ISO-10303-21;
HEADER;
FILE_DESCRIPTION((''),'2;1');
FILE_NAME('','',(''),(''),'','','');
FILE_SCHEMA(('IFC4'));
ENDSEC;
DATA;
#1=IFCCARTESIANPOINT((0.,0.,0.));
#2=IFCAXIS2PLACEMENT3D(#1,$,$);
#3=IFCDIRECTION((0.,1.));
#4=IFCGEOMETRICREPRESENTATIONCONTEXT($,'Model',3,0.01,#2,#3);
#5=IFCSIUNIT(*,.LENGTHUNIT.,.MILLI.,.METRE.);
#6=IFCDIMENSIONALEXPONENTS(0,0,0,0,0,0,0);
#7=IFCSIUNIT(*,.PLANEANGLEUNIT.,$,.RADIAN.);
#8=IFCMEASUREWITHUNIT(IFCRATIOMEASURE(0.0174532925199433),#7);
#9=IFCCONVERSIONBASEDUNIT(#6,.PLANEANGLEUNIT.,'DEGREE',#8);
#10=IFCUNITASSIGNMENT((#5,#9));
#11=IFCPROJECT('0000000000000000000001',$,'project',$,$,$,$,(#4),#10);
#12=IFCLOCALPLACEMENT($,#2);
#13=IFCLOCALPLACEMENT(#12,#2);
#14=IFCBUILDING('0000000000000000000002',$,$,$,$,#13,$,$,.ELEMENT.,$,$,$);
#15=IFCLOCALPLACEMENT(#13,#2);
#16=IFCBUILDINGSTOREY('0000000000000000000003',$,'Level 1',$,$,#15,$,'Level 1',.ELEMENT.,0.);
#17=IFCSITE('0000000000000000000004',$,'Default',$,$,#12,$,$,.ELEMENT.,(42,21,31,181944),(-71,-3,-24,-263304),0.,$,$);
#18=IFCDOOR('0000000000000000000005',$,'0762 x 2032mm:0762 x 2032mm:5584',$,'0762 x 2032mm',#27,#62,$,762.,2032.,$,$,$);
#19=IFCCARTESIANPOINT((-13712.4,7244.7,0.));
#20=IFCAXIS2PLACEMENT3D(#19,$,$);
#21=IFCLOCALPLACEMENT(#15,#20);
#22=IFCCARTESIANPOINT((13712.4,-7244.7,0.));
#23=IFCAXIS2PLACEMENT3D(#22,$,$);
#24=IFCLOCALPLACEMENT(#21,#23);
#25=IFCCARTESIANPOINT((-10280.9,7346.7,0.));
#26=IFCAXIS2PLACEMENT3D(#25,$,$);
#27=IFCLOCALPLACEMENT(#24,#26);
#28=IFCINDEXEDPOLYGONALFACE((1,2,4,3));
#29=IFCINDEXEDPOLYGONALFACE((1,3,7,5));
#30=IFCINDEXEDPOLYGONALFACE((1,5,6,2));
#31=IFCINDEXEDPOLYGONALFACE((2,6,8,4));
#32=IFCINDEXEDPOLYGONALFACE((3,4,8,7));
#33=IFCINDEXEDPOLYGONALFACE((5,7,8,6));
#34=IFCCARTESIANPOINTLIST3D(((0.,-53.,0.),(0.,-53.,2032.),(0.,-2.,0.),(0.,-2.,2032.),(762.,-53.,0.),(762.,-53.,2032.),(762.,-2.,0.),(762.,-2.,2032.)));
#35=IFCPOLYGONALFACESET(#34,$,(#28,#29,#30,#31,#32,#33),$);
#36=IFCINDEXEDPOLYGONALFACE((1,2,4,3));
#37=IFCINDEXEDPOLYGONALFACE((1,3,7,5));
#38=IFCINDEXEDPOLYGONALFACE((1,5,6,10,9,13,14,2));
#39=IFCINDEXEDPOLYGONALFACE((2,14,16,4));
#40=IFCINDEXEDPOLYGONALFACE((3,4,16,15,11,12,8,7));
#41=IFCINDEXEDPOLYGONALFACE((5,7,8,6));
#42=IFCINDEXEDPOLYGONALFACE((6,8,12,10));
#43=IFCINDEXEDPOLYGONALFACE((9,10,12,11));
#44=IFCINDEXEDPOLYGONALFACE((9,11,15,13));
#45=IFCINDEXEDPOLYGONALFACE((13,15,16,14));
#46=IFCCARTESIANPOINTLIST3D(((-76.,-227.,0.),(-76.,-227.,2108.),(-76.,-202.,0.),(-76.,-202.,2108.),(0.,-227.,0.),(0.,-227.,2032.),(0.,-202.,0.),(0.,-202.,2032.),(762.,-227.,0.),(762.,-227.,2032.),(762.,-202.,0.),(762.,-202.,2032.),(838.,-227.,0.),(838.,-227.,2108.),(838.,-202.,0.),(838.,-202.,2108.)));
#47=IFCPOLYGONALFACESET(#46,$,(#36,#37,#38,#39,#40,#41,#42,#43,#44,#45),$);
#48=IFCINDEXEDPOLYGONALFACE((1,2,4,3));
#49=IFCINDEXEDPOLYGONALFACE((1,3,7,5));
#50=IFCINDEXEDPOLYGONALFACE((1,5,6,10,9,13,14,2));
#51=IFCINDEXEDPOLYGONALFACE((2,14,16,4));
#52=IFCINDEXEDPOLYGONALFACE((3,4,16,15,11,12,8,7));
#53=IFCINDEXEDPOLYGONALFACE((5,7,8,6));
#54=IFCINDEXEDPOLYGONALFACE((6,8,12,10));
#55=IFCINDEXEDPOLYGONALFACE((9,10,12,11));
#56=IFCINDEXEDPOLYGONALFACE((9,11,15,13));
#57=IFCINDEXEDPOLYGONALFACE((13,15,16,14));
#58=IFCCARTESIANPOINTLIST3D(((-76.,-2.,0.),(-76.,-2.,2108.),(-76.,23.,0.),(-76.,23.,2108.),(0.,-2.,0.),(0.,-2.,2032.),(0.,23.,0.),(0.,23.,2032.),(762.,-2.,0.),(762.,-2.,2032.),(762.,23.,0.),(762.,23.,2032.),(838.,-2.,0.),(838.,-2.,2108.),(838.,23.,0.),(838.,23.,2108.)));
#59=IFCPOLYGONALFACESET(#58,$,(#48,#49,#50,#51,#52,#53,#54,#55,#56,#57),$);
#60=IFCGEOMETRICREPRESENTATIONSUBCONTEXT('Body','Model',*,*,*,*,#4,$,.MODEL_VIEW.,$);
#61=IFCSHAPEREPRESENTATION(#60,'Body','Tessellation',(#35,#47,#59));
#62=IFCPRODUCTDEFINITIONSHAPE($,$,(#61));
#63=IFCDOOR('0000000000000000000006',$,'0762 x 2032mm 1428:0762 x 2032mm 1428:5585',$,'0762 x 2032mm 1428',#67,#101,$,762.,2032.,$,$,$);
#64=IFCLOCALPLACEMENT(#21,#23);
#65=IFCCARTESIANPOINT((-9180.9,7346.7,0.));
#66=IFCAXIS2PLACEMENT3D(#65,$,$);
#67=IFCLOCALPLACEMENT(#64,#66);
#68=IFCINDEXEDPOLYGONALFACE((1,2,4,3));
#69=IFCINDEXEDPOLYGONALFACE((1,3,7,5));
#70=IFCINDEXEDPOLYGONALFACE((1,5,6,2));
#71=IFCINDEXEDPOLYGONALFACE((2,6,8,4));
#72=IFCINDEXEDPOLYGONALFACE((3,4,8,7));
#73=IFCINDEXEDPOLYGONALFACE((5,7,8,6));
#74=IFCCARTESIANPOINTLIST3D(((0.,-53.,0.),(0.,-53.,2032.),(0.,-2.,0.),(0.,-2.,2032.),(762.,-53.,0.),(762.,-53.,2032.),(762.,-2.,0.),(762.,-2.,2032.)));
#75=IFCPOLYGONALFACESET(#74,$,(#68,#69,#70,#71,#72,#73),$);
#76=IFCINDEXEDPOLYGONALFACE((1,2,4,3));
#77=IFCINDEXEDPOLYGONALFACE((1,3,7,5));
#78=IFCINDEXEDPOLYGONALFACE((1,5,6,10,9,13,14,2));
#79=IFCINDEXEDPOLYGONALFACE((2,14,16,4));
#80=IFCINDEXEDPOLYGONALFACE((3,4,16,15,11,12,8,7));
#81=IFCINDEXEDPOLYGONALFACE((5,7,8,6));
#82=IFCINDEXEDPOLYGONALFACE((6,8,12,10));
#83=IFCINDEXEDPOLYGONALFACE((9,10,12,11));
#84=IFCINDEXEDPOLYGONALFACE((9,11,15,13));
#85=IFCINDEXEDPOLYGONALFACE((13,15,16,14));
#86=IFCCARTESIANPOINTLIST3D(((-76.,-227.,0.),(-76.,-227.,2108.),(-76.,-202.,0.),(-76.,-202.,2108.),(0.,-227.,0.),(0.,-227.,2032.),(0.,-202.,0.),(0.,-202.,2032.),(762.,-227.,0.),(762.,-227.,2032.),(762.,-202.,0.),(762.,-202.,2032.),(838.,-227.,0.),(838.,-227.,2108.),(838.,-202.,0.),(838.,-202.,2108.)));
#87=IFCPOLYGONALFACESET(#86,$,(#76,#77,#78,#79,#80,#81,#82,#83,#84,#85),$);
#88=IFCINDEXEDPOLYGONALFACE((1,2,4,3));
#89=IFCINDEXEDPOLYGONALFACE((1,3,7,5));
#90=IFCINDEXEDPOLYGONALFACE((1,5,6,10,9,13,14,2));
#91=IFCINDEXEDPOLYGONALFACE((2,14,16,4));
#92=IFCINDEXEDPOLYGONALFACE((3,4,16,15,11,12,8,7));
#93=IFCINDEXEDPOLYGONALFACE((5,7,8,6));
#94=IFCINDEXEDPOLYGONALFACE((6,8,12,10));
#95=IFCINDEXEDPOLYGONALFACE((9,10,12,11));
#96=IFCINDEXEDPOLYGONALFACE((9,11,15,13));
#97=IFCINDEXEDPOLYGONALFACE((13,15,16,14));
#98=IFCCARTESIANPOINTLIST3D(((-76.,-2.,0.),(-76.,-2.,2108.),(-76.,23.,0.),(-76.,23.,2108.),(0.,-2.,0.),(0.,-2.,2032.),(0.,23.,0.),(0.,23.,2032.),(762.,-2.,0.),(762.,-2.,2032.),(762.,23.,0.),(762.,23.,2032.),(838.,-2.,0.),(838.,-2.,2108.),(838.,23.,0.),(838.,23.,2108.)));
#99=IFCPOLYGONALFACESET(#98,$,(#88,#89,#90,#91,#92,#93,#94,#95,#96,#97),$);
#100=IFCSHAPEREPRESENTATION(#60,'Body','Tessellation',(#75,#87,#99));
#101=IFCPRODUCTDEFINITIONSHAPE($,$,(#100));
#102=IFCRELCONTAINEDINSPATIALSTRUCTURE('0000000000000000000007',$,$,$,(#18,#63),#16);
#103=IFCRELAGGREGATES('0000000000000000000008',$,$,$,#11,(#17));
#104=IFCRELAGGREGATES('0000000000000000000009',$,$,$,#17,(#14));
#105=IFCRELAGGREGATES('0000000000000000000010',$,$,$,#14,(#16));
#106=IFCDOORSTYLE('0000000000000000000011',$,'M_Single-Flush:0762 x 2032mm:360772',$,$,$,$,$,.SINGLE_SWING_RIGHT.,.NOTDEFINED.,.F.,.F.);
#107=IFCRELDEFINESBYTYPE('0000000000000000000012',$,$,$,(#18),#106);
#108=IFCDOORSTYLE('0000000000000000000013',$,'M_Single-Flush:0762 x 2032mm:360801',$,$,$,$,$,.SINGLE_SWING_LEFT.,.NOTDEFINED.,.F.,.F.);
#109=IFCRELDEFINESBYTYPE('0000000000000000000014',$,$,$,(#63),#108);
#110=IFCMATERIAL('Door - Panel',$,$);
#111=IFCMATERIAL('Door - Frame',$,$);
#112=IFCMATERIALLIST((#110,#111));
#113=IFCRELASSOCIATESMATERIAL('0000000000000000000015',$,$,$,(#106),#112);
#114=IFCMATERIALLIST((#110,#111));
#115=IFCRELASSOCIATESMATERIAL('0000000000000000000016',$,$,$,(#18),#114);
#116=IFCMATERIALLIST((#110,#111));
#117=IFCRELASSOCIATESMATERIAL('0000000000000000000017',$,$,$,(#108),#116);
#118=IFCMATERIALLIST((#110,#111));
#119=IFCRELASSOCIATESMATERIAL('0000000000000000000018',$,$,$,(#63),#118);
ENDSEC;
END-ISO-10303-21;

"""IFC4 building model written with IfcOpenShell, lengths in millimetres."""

from ifc_helpers import new_model, entity, si_unit, converted_unit, direction, frame, frame_2d, origin, origin_2d_with_axis, place, context, subcontext, project, spatial, polyline, rectangle, outline, extrude, source, transform, mapped, material, material_list, type_object, type_shapes, element, save


model = new_model("IFC4")

# Units and contexts
model_context = context("Model", 3, precision=0.01, world=origin(), true_north=direction((0.0, 1.0)))
body_context = subcontext(model_context, "Body", "Model", "MODEL_VIEW")
ifc_project = project(units=[si_unit("LENGTHUNIT", "METRE", prefix="MILLI"), converted_unit("PLANEANGLEUNIT", "DEGREE", entity("IfcRatioMeasure", 0.0174532925199433), si_unit("PLANEANGLEUNIT", "RADIAN"), dimensions=[0, 0, 0, 0, 0, 0, 0])], contexts=[model_context])

# Site, building, storey
site_placement = place(None, origin())
site = spatial("IfcSite", under=ifc_project, at=site_placement, Name="Default", CompositionType="ELEMENT", RefLatitude=(42, 21, 31, 181944), RefLongitude=(-71, -3, -24, -263304), RefElevation=0.0)
building_placement = place(site_placement, origin())
building = spatial("IfcBuilding", under=site, at=building_placement, CompositionType="ELEMENT")
storey_placement = place(building_placement, origin())
storey = spatial("IfcBuildingStorey", under=building, at=storey_placement, Name="Level 1", LongName="Level 1", CompositionType="ELEMENT", Elevation=0.0)

# Shared definitions
placement_1 = place(storey_placement, frame((-13712.4, 7244.7, 0.0)))

# Doors
ifc_material_1 = material(Name="Door - Panel")
ifc_material_2 = material(Name="Door - Frame")
ifc_material_list_1 = material_list([ifc_material_1, ifc_material_2])
ifc_material_list_2 = material_list([ifc_material_1, ifc_material_2])
door_style_1 = type_object("IfcDoorStyle", Name="M_Single-Flush:0762 x 2032mm:360772", ConstructionType="NOTDEFINED", OperationType="SINGLE_SWING_RIGHT", ParameterTakesPrecedence=False, Sizeable=False, material=ifc_material_list_2)
shared_shape_1 = source(origin(), body_context, "Body", "SweptSolid", [
    extrude(rectangle(XDim=762.0, YDim=51.0, at=frame_2d((0.0, 0.0), x_axis=(1.0, 0.0))), frame((381.0, -27.5, 0.0), z_axis=(0.0, 0.0, 1.0), x_axis=(-1.0, 0.0, 0.0)), (0.0, 0.0, 1.0), 2032.0),
    extrude(outline(polyline([(-457.0, -1035.0), (-381.0, -1035.0), (-381.0, 997.0), (381.0, 997.0), (381.0, -1035.0), (457.0, -1035.0), (457.0, 1073.0), (-457.0, 1073.0), (-457.0, -1035.0)])), frame((381.0, -227.0, 1035.0), z_axis=(0.0, 1.0, 0.0), x_axis=(-1.0, 0.0, 0.0)), (0.0, 0.0, 1.0), 25.0),
    extrude(outline(polyline([(-1073.0, -457.0), (1035.0, -457.0), (1035.0, -381.0), (-997.0, -381.0), (-997.0, 381.0), (1035.0, 381.0), (1035.0, 457.0), (-1073.0, 457.0), (-1073.0, -457.0)])), frame((381.0, -2.0, 1035.0), z_axis=(0.0, 1.0, 0.0), x_axis=(0.0, 0.0, -1.0)), (0.0, 0.0, 1.0), 25.0),
])
type_shapes(door_style_1, [shared_shape_1])
placement_2 = place(placement_1, frame((13712.4, -7244.7, 0.0)))
door_1_placement = place(placement_2, frame((-10280.9, 7346.7, 0.0)))
element("IfcDoor", 1, at=door_1_placement, inside=storey, type_object=door_style_1, material=ifc_material_list_1, Name="0762 x 2032mm:0762 x 2032mm:5584", ObjectType="0762 x 2032mm", OverallHeight=762.0, OverallWidth=2032.0, context=body_context, shape_type="MappedRepresentation", body=[
    mapped(shared_shape_1, transform((0.0, 0.0, 0.0), scale=1.0)),
])
ifc_material_list_3 = material_list([ifc_material_1, ifc_material_2])
ifc_material_list_4 = material_list([ifc_material_1, ifc_material_2])
door_style_2 = type_object("IfcDoorStyle", Name="M_Single-Flush:0762 x 2032mm:360801", ConstructionType="NOTDEFINED", OperationType="SINGLE_SWING_LEFT", ParameterTakesPrecedence=False, Sizeable=False, material=ifc_material_list_4)
shared_shape_2 = source(origin(), body_context, "Body", "SweptSolid", [
    extrude(rectangle(XDim=51.0, YDim=762.0, at=origin_2d_with_axis()), frame((381.0, -27.5, 0.0), z_axis=(0.0, 0.0, 1.0), x_axis=(0.0, 1.0, 0.0)), (0.0, 0.0, 1.0), 2032.0),
    extrude(outline(polyline([(-1035.0, -457.0), (1073.0, -457.0), (1073.0, 457.0), (-1035.0, 457.0), (-1035.0, 381.0), (997.0, 381.0), (997.0, -381.0), (-1035.0, -381.0), (-1035.0, -457.0)])), frame((381.0, -227.0, 1035.0), z_axis=(0.0, 1.0, 0.0), x_axis=(0.0, 0.0, 1.0)), (0.0, 0.0, 1.0), 25.0),
    extrude(outline(polyline([(-457.0, -1073.0), (457.0, -1073.0), (457.0, 1035.0), (381.0, 1035.0), (381.0, -997.0), (-381.0, -997.0), (-381.0, 1035.0), (-457.0, 1035.0), (-457.0, -1073.0)])), frame((381.0, -2.0, 1035.0), z_axis=(0.0, 1.0, 0.0), x_axis=(1.0, 0.0, 0.0)), (0.0, 0.0, 1.0), 25.0),
])
type_shapes(door_style_2, [shared_shape_2])
placement_3 = place(placement_1, frame((13712.4, -7244.7, 0.0)))
door_2_placement = place(placement_3, frame((-9180.9, 7346.7, 0.0)))
element("IfcDoor", 2, at=door_2_placement, inside=storey, type_object=door_style_2, material=ifc_material_list_3, Name="0762 x 2032mm 1428:0762 x 2032mm 1428:5585", ObjectType="0762 x 2032mm 1428", OverallHeight=762.0, OverallWidth=2032.0, context=body_context, shape_type="MappedRepresentation", body=[
    mapped(shared_shape_2, transform((0.0, 0.0, 0.0), scale=1.0)),
])

save(model, "model.ifc")
